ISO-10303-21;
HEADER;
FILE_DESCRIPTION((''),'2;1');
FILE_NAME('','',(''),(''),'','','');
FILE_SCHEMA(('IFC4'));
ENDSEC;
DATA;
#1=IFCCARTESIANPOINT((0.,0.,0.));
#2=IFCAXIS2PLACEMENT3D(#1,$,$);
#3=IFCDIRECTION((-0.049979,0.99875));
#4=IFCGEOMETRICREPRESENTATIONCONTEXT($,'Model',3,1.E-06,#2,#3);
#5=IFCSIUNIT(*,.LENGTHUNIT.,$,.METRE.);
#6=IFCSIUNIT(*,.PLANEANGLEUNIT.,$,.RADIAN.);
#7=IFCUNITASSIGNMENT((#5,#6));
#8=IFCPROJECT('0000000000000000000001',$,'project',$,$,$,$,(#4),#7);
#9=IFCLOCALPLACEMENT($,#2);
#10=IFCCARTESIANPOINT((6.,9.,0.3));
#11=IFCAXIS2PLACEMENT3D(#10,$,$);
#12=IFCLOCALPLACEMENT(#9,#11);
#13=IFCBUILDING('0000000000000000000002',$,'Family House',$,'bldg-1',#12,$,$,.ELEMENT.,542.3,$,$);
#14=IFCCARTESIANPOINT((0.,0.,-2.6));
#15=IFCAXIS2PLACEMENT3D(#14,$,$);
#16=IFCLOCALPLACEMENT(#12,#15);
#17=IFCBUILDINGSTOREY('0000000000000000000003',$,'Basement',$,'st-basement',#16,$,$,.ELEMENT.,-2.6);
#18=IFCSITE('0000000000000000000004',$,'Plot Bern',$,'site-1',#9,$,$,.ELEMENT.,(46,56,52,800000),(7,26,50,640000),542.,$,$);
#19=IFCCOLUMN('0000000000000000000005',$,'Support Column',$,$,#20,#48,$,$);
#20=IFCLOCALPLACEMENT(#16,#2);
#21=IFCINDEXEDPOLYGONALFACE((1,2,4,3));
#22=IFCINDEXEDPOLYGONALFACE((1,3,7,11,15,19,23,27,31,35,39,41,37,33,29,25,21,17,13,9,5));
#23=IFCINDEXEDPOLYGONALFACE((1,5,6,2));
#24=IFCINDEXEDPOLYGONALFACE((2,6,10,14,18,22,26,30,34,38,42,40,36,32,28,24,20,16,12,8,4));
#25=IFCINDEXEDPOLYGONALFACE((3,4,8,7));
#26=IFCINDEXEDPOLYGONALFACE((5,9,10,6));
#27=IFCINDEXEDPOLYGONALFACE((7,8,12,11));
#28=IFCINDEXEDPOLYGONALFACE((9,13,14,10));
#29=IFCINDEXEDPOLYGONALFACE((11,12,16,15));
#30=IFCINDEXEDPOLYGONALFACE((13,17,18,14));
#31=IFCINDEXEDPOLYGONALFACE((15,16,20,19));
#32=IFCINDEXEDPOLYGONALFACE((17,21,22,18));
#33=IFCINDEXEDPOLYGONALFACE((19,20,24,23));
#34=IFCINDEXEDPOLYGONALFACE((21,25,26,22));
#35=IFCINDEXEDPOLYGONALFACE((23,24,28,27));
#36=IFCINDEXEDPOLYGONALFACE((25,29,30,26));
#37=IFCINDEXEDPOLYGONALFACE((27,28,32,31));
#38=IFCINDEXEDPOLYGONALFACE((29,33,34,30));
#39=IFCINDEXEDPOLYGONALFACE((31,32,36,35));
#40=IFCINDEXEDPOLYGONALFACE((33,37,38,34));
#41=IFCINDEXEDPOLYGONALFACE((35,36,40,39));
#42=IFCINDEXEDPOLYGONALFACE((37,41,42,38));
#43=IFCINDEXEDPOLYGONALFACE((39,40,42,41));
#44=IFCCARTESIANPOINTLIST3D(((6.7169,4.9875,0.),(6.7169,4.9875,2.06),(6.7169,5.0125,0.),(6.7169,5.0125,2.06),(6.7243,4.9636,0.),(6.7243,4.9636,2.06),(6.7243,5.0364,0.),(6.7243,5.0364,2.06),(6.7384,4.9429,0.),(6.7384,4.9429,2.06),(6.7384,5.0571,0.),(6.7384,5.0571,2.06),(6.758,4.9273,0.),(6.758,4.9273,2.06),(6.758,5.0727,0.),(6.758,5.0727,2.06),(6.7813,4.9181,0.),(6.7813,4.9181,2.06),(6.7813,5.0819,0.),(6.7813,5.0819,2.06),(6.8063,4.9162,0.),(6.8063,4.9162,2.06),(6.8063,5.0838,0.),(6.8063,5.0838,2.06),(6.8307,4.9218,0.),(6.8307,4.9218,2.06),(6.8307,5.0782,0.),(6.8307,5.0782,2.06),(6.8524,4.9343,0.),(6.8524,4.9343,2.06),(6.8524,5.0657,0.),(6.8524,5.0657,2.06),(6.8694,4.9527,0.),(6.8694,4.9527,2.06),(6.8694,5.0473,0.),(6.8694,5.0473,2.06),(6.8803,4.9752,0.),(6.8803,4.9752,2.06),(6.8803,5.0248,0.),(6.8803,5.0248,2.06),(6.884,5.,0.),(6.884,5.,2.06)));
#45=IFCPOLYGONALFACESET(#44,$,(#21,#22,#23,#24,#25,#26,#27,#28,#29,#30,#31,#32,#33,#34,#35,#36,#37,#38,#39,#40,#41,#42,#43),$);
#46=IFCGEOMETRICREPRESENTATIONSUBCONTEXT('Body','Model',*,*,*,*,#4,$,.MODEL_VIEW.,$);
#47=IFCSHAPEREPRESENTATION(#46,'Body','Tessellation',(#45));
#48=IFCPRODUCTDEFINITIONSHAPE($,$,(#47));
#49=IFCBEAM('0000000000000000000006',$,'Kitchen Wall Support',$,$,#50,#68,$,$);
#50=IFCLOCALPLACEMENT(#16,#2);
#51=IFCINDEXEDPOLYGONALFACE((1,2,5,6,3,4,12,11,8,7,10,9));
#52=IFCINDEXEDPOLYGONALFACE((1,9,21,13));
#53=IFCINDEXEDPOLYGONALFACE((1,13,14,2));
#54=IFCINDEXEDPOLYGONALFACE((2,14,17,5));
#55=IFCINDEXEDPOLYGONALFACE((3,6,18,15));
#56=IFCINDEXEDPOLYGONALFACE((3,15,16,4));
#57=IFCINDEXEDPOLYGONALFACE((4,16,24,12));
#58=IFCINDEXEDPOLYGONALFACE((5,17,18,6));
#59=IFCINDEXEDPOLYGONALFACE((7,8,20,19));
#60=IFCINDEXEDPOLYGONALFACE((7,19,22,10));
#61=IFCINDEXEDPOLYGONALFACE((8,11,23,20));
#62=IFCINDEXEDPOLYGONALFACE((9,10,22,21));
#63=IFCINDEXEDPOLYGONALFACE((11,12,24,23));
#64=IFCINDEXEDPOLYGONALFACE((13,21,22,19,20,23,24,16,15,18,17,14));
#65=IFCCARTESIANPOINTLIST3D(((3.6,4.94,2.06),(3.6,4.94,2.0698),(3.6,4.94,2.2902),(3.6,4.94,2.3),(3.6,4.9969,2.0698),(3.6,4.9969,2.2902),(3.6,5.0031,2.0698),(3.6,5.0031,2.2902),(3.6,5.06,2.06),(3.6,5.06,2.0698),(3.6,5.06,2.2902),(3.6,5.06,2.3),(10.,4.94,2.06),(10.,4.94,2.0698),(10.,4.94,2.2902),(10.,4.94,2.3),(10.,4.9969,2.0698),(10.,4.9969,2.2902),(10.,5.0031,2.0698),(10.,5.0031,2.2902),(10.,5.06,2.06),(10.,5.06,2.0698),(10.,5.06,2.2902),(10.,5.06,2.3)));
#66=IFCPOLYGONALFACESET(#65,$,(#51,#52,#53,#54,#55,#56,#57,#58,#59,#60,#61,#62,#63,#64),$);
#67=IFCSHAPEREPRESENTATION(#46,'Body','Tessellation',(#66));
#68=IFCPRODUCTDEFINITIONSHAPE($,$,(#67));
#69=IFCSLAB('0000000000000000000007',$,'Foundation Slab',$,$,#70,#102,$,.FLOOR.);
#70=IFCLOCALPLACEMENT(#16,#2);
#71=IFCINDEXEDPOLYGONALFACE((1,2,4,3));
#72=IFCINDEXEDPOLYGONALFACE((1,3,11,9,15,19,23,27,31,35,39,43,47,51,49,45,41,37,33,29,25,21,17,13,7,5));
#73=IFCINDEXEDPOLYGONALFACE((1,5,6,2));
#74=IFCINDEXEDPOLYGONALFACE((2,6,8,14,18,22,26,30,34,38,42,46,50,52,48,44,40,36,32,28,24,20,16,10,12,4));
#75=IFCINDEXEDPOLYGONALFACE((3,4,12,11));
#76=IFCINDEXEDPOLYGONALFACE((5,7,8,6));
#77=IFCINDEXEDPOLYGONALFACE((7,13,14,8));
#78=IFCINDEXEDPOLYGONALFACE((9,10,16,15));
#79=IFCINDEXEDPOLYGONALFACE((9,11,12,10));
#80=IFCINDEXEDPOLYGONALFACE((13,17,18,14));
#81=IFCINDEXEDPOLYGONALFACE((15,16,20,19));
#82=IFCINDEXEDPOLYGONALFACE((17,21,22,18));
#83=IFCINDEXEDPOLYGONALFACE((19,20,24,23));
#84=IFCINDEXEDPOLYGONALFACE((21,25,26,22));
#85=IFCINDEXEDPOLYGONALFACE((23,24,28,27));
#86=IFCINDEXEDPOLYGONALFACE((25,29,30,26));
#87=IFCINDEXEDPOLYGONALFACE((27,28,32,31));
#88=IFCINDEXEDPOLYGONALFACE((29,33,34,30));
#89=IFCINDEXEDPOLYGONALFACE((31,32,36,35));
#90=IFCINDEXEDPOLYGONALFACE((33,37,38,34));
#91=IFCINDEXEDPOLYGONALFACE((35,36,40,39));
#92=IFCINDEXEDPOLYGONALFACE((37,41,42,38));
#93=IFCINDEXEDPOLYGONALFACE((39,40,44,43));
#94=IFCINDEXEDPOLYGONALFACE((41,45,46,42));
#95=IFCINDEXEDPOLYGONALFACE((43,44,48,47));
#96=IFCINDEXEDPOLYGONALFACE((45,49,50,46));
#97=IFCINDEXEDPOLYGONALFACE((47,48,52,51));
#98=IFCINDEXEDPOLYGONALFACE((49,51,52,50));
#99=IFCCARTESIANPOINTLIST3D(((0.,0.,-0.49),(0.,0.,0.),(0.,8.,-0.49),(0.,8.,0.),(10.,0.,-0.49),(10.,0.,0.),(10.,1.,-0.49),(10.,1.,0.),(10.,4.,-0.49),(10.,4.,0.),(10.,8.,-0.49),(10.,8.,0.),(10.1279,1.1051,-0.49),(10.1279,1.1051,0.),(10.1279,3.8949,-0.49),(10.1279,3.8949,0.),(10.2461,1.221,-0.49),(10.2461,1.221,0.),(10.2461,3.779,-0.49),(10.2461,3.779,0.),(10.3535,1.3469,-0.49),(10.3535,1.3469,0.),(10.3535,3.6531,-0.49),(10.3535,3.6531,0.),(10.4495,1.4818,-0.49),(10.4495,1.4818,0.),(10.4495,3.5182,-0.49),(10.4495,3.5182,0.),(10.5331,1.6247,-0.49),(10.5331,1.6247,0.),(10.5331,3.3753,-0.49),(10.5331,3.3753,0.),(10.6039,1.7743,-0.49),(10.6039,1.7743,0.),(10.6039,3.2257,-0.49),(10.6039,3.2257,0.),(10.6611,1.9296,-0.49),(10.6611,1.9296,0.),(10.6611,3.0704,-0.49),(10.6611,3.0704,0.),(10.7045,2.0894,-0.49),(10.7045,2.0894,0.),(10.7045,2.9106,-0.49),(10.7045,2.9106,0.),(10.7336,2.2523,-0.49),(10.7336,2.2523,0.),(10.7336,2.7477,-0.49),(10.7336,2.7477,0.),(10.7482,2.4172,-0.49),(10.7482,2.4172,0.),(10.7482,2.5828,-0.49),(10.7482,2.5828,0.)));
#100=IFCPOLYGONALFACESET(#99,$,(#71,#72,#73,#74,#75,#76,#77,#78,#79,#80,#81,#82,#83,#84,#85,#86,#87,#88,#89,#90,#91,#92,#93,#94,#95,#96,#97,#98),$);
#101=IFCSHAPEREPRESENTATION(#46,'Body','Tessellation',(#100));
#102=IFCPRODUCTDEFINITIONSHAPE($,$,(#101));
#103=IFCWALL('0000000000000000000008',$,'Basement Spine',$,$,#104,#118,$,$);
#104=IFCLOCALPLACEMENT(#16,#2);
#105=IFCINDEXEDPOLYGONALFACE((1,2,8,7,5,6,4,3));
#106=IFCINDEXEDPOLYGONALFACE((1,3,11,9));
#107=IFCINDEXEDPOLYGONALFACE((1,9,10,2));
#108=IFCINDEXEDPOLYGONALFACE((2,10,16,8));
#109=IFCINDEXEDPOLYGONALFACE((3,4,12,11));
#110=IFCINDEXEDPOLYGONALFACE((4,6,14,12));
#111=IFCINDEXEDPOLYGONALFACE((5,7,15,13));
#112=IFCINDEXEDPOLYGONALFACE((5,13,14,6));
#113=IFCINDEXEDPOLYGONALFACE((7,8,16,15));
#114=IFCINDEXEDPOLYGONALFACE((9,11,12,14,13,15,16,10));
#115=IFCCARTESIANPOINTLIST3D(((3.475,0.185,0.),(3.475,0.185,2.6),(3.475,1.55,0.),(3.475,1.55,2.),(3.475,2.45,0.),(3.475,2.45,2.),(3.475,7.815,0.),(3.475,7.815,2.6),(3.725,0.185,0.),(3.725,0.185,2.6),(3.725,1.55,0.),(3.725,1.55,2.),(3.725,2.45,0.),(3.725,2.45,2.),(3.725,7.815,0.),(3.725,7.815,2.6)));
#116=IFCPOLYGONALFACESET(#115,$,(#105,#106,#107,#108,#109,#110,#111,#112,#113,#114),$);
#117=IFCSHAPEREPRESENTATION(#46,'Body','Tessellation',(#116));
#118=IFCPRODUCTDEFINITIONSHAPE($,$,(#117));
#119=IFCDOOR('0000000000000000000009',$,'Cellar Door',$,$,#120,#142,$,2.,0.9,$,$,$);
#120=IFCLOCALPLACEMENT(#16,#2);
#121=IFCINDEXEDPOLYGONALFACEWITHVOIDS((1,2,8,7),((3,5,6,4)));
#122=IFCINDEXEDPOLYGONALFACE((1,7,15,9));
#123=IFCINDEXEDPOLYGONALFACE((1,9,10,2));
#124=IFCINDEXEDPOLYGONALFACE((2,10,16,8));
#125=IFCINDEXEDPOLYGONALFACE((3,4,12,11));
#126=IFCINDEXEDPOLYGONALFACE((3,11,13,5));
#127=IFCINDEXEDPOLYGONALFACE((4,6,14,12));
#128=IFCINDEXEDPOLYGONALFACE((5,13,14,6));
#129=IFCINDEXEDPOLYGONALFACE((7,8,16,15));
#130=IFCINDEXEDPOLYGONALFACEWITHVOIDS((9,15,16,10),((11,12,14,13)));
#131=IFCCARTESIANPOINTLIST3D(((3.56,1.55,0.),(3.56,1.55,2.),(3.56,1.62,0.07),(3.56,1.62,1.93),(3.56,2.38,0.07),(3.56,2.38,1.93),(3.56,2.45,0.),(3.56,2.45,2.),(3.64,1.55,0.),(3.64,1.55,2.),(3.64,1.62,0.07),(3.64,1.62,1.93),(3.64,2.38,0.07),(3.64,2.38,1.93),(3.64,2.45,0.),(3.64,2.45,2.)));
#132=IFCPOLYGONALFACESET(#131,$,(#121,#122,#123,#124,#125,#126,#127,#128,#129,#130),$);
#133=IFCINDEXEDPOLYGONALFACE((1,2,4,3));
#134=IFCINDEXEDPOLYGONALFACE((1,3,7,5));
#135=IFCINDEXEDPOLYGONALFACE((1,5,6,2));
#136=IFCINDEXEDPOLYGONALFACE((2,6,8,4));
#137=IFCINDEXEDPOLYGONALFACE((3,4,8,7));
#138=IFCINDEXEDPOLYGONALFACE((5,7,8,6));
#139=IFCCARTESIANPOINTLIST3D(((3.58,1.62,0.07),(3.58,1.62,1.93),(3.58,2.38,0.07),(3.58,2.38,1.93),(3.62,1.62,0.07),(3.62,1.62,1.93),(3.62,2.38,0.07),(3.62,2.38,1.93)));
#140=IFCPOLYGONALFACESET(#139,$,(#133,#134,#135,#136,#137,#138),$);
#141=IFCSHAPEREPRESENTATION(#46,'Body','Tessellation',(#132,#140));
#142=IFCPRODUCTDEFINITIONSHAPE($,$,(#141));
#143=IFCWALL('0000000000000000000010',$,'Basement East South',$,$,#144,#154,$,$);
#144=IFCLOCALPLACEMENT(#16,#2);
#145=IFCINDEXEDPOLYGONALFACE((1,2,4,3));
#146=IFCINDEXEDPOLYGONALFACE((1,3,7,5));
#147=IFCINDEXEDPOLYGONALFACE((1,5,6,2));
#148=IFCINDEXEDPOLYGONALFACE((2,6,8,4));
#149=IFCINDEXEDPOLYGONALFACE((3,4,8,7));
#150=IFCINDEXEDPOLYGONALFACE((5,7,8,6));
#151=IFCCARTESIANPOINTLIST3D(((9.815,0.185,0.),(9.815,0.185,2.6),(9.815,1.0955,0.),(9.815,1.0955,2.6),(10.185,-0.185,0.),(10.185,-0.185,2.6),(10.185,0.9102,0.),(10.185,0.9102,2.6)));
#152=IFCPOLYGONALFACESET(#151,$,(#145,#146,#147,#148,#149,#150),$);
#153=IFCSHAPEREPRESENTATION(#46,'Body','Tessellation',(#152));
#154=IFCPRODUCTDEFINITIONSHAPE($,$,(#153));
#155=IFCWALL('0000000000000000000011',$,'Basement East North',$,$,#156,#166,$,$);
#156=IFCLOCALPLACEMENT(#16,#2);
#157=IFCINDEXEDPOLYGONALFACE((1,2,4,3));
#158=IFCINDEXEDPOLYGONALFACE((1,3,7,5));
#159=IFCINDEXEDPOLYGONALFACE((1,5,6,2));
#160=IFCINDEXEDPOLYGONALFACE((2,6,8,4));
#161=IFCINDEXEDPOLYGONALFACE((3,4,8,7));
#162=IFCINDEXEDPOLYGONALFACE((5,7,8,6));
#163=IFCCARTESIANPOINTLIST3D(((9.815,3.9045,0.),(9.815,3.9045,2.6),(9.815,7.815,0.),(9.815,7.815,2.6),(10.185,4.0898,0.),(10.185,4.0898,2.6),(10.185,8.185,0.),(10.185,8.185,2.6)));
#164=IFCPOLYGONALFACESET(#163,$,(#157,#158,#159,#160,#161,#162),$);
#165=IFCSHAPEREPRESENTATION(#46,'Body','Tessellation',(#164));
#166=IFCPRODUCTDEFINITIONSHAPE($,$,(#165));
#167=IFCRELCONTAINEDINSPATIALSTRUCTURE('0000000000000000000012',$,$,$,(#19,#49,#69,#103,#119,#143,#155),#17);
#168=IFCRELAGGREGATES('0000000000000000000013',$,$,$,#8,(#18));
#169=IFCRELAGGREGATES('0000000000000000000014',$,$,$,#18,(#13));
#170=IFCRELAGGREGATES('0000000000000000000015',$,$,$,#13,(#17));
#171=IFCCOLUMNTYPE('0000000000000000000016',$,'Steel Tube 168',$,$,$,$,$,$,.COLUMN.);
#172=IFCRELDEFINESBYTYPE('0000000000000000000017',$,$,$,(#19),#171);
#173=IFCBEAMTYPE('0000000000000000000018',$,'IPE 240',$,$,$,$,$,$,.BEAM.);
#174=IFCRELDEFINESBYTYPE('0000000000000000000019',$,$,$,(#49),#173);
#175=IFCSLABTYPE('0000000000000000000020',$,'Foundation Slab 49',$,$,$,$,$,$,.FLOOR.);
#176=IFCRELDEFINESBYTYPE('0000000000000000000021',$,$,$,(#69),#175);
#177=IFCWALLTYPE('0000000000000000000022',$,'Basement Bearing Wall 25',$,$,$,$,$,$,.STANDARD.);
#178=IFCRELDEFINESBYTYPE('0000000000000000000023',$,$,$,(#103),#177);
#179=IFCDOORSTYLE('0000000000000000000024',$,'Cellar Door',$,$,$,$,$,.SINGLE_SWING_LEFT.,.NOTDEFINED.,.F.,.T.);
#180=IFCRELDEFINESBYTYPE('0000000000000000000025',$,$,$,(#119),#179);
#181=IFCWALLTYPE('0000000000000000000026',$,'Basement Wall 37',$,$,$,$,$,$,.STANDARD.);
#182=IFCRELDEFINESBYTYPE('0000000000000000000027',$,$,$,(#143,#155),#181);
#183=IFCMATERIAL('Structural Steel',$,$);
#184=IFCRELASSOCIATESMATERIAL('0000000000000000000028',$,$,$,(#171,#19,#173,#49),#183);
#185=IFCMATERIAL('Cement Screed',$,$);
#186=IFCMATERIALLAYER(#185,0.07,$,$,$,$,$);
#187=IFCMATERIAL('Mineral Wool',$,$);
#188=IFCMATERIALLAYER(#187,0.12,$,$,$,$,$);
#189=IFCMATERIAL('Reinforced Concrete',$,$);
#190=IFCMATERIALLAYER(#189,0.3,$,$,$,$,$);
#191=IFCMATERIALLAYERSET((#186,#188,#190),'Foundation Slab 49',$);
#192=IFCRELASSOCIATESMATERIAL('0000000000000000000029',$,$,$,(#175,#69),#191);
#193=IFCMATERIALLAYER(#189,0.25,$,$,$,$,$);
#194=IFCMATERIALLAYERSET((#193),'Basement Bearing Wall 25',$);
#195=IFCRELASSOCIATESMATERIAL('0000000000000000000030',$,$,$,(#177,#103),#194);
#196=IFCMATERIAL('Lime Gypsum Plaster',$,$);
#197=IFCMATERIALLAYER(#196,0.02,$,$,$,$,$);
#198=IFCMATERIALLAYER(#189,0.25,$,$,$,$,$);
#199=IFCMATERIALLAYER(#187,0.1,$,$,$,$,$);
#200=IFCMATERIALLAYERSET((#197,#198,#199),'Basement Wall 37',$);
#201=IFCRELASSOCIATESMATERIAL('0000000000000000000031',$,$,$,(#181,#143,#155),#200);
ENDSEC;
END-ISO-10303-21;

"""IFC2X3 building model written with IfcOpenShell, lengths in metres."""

from ifc_helpers import new_model, si_unit, point, direction, frame, frame_2d, origin, origin_2d, place, context, subcontext, project, spatial, polyline, circle_curve, trimmed, segment, composite_curve, rectangle, circle, i_section, outline, extrude, material, layer, layer_set, layer_usage, type_object, element, fill, save


model = new_model("IFC2X3")

# Units and contexts
model_context = context("Model", 3, precision=1e-06, world=origin(), true_north=direction((-0.049979, 0.99875)))
body_context = subcontext(model_context, "Body", "Model", "MODEL_VIEW")
ifc_project = project(units=[si_unit("LENGTHUNIT", "METRE"), si_unit("PLANEANGLEUNIT", "RADIAN")], contexts=[model_context])

# Site, building, storey
site_placement = place(None, origin())
site = spatial("IfcSite", under=ifc_project, at=site_placement, Name="Plot Bern", ObjectType="site-1", CompositionType="ELEMENT", RefLatitude=(46, 56, 52, 800000), RefLongitude=(7, 26, 50, 640000), RefElevation=542.0)
building_placement = place(site_placement, frame((6.0, 9.0, 0.3)))
building = spatial("IfcBuilding", under=site, at=building_placement, Name="Family House", ObjectType="bldg-1", CompositionType="ELEMENT", ElevationOfRefHeight=542.3)
storey_placement = place(building_placement, frame((0.0, 0.0, -2.6)))
storey = spatial("IfcBuildingStorey", under=building, at=storey_placement, Name="Basement", ObjectType="st-basement", CompositionType="ELEMENT", Elevation=-2.6)

# Column
ifc_material_1 = material(Name="Structural Steel")
column_type = type_object("IfcColumnType", Name="Steel Tube 168", PredefinedType="COLUMN", material=ifc_material_1)
column_placement = place(storey_placement, frame((6.8, 5.0, 0.0)))
element("IfcColumn", 1, at=column_placement, inside=storey, type_object=column_type, material=ifc_material_1, Name="Support Column", context=body_context, shape_type="SweptSolid", body=[
    extrude(circle(Radius=0.084, at=origin_2d()), origin(), (0.0, 0.0, 1.0), 2.06),
])

# Beam
beam_type = type_object("IfcBeamType", Name="IPE 240", PredefinedType="BEAM", material=ifc_material_1)
beam_placement = place(storey_placement, frame((3.6, 5.0, 2.18), z_axis=(1.0, 0.0, 0.0), x_axis=(0.0, 1.0, 0.0)))
element("IfcBeam", 2, at=beam_placement, inside=storey, type_object=beam_type, material=ifc_material_1, Name="Kitchen Wall Support", context=body_context, shape_type="SweptSolid", body=[
    extrude(i_section(OverallWidth=0.12, OverallDepth=0.24, WebThickness=0.0062, FlangeThickness=0.0098, at=origin_2d()), origin(), (0.0, 0.0, 1.0), 6.4),
])

# Slab
ifc_material_2 = material(Name="Cement Screed")
ifc_layer_1 = layer(ifc_material_2, 0.07)
ifc_material_3 = material(Name="Mineral Wool")
ifc_layer_2 = layer(ifc_material_3, 0.12)
ifc_material_4 = material(Name="Reinforced Concrete")
ifc_layer_3 = layer(ifc_material_4, 0.3)
ifc_layer_set_1 = layer_set([ifc_layer_1, ifc_layer_2, ifc_layer_3], Name="Foundation Slab 49")
ifc_layer_usage_1 = layer_usage(ifc_layer_set_1, "AXIS3", "NEGATIVE", 0.49)
slab_type = type_object("IfcSlabType", Name="Foundation Slab 49", PredefinedType="FLOOR", material=ifc_layer_set_1)
slab_placement = place(storey_placement, frame((0.0, 0.0, -0.49)))
element("IfcSlab", 3, at=slab_placement, inside=storey, type_object=slab_type, material=ifc_layer_usage_1, Name="Foundation Slab", PredefinedType="FLOOR", context=body_context, shape_type="SweptSolid", body=[
    extrude(outline(composite_curve([segment(polyline([(0.0, 0.0), (10.0, 0.0)]), True, "CONTINUOUS"), segment(polyline([(10.0, 0.0), (10.0, 1.0)]), True, "CONTINUOUS"), segment(trimmed(circle_curve(frame_2d((8.875, 2.5)), 1.875), [point((10.0, 1.0))], [point((10.0, 4.0))], True, "CARTESIAN"), True, "CONTINUOUS"), segment(polyline([(10.0, 4.0), (10.0, 8.0)]), True, "CONTINUOUS"), segment(polyline([(10.0, 8.0), (0.0, 8.0)]), True, "CONTINUOUS"), segment(polyline([(0.0, 8.0), (0.0, 0.0)]), True, "CONTINUOUS")], self_intersect=False)), origin(), (0.0, 0.0, 1.0), 0.49),
])

# Wall, opening, door
ifc_layer_4 = layer(ifc_material_4, 0.25)
ifc_layer_set_2 = layer_set([ifc_layer_4], Name="Basement Bearing Wall 25")
ifc_layer_usage_2 = layer_usage(ifc_layer_set_2, "AXIS2", "NEGATIVE", 0.125)
wall_type_1 = type_object("IfcWallType", Name="Basement Bearing Wall 25", PredefinedType="STANDARD", material=ifc_layer_set_2)
wall_1_placement = place(storey_placement, origin())
wall_1 = element("IfcWall", 4, at=wall_1_placement, inside=storey, type_object=wall_type_1, material=ifc_layer_usage_2, Name="Basement Spine", context=body_context, shape_type="SweptSolid", body=[
    extrude(outline(polyline([(3.725, 0.185), (3.725, 7.815), (3.475, 7.815), (3.475, 0.185), (3.725, 0.185)])), origin(), (0.0, 0.0, 1.0), 2.6),
])
opening_1_placement = place(wall_1_placement, frame((3.6, 2.0, 0.0), z_axis=(0.0, 0.0, 1.0), x_axis=(0.0, 1.0, 0.0)))
opening_1 = element("IfcOpeningElement", 5, at=opening_1_placement, cuts=wall_1, context=body_context, shape_type="SweptSolid", body=[
    extrude(rectangle(XDim=0.9, YDim=0.25, at=origin_2d()), origin(), (0.0, 0.0, 1.0), 2.0),
])
door_style = type_object("IfcDoorStyle", Name="Cellar Door", ConstructionType="NOTDEFINED", OperationType="SINGLE_SWING_LEFT", ParameterTakesPrecedence=False, Sizeable=True)
door_placement = place(opening_1_placement, frame((0.0, 0.0, 0.0), z_axis=(0.0, 1.0, 0.0), x_axis=(-1.0, 0.0, 0.0)))
door = element("IfcDoor", 6, at=door_placement, inside=storey, type_object=door_style, Name="Cellar Door", OverallHeight=2.0, OverallWidth=0.9, context=body_context, shape_type="SweptSolid", body=[
    extrude(outline(polyline([(-0.45, 0.0), (0.45, 0.0), (0.45, 2.0), (-0.45, 2.0), (-0.45, 0.0)]), holes=[polyline([(-0.38, 0.07), (0.38, 0.07), (0.38, 1.93), (-0.38, 1.93), (-0.38, 0.07)])]), frame((0.0, 0.0, -0.04)), (0.0, 0.0, 1.0), 0.08),
    extrude(rectangle(XDim=0.76, YDim=1.86, at=frame_2d((0.0, 1.0))), frame((0.0, 0.0, -0.02)), (0.0, 0.0, 1.0), 0.04),
])
fill(opening_1, door)

# Walls
ifc_material_5 = material(Name="Lime Gypsum Plaster")
ifc_layer_5 = layer(ifc_material_5, 0.02)
ifc_layer_6 = layer(ifc_material_4, 0.25)
ifc_layer_7 = layer(ifc_material_3, 0.1)
ifc_layer_set_3 = layer_set([ifc_layer_5, ifc_layer_6, ifc_layer_7], Name="Basement Wall 37")
wall_type_2 = type_object("IfcWallType", Name="Basement Wall 37", PredefinedType="STANDARD", material=ifc_layer_set_3)
ifc_layer_usage_3 = layer_usage(ifc_layer_set_3, "AXIS2", "NEGATIVE", 0.185)
wall_2_placement = place(storey_placement, origin())
element("IfcWall", 7, at=wall_2_placement, inside=storey, type_object=wall_type_2, material=ifc_layer_usage_3, Name="Basement East South", context=body_context, shape_type="SweptSolid", body=[
    extrude(outline(polyline([(10.185, -0.185), (10.185, 0.9102), (9.815, 1.0955), (9.815, 0.185), (10.185, -0.185)])), origin(), (0.0, 0.0, 1.0), 2.6),
])
ifc_layer_usage_4 = layer_usage(ifc_layer_set_3, "AXIS2", "NEGATIVE", 0.185)
wall_3_placement = place(storey_placement, origin())
element("IfcWall", 8, at=wall_3_placement, inside=storey, type_object=wall_type_2, material=ifc_layer_usage_4, Name="Basement East North", context=body_context, shape_type="SweptSolid", body=[
    extrude(outline(polyline([(10.185, 4.0898), (10.185, 8.185), (9.815, 7.815), (9.815, 3.9045), (10.185, 4.0898)])), origin(), (0.0, 0.0, 1.0), 2.6),
])

save(model, "model.ifc")
